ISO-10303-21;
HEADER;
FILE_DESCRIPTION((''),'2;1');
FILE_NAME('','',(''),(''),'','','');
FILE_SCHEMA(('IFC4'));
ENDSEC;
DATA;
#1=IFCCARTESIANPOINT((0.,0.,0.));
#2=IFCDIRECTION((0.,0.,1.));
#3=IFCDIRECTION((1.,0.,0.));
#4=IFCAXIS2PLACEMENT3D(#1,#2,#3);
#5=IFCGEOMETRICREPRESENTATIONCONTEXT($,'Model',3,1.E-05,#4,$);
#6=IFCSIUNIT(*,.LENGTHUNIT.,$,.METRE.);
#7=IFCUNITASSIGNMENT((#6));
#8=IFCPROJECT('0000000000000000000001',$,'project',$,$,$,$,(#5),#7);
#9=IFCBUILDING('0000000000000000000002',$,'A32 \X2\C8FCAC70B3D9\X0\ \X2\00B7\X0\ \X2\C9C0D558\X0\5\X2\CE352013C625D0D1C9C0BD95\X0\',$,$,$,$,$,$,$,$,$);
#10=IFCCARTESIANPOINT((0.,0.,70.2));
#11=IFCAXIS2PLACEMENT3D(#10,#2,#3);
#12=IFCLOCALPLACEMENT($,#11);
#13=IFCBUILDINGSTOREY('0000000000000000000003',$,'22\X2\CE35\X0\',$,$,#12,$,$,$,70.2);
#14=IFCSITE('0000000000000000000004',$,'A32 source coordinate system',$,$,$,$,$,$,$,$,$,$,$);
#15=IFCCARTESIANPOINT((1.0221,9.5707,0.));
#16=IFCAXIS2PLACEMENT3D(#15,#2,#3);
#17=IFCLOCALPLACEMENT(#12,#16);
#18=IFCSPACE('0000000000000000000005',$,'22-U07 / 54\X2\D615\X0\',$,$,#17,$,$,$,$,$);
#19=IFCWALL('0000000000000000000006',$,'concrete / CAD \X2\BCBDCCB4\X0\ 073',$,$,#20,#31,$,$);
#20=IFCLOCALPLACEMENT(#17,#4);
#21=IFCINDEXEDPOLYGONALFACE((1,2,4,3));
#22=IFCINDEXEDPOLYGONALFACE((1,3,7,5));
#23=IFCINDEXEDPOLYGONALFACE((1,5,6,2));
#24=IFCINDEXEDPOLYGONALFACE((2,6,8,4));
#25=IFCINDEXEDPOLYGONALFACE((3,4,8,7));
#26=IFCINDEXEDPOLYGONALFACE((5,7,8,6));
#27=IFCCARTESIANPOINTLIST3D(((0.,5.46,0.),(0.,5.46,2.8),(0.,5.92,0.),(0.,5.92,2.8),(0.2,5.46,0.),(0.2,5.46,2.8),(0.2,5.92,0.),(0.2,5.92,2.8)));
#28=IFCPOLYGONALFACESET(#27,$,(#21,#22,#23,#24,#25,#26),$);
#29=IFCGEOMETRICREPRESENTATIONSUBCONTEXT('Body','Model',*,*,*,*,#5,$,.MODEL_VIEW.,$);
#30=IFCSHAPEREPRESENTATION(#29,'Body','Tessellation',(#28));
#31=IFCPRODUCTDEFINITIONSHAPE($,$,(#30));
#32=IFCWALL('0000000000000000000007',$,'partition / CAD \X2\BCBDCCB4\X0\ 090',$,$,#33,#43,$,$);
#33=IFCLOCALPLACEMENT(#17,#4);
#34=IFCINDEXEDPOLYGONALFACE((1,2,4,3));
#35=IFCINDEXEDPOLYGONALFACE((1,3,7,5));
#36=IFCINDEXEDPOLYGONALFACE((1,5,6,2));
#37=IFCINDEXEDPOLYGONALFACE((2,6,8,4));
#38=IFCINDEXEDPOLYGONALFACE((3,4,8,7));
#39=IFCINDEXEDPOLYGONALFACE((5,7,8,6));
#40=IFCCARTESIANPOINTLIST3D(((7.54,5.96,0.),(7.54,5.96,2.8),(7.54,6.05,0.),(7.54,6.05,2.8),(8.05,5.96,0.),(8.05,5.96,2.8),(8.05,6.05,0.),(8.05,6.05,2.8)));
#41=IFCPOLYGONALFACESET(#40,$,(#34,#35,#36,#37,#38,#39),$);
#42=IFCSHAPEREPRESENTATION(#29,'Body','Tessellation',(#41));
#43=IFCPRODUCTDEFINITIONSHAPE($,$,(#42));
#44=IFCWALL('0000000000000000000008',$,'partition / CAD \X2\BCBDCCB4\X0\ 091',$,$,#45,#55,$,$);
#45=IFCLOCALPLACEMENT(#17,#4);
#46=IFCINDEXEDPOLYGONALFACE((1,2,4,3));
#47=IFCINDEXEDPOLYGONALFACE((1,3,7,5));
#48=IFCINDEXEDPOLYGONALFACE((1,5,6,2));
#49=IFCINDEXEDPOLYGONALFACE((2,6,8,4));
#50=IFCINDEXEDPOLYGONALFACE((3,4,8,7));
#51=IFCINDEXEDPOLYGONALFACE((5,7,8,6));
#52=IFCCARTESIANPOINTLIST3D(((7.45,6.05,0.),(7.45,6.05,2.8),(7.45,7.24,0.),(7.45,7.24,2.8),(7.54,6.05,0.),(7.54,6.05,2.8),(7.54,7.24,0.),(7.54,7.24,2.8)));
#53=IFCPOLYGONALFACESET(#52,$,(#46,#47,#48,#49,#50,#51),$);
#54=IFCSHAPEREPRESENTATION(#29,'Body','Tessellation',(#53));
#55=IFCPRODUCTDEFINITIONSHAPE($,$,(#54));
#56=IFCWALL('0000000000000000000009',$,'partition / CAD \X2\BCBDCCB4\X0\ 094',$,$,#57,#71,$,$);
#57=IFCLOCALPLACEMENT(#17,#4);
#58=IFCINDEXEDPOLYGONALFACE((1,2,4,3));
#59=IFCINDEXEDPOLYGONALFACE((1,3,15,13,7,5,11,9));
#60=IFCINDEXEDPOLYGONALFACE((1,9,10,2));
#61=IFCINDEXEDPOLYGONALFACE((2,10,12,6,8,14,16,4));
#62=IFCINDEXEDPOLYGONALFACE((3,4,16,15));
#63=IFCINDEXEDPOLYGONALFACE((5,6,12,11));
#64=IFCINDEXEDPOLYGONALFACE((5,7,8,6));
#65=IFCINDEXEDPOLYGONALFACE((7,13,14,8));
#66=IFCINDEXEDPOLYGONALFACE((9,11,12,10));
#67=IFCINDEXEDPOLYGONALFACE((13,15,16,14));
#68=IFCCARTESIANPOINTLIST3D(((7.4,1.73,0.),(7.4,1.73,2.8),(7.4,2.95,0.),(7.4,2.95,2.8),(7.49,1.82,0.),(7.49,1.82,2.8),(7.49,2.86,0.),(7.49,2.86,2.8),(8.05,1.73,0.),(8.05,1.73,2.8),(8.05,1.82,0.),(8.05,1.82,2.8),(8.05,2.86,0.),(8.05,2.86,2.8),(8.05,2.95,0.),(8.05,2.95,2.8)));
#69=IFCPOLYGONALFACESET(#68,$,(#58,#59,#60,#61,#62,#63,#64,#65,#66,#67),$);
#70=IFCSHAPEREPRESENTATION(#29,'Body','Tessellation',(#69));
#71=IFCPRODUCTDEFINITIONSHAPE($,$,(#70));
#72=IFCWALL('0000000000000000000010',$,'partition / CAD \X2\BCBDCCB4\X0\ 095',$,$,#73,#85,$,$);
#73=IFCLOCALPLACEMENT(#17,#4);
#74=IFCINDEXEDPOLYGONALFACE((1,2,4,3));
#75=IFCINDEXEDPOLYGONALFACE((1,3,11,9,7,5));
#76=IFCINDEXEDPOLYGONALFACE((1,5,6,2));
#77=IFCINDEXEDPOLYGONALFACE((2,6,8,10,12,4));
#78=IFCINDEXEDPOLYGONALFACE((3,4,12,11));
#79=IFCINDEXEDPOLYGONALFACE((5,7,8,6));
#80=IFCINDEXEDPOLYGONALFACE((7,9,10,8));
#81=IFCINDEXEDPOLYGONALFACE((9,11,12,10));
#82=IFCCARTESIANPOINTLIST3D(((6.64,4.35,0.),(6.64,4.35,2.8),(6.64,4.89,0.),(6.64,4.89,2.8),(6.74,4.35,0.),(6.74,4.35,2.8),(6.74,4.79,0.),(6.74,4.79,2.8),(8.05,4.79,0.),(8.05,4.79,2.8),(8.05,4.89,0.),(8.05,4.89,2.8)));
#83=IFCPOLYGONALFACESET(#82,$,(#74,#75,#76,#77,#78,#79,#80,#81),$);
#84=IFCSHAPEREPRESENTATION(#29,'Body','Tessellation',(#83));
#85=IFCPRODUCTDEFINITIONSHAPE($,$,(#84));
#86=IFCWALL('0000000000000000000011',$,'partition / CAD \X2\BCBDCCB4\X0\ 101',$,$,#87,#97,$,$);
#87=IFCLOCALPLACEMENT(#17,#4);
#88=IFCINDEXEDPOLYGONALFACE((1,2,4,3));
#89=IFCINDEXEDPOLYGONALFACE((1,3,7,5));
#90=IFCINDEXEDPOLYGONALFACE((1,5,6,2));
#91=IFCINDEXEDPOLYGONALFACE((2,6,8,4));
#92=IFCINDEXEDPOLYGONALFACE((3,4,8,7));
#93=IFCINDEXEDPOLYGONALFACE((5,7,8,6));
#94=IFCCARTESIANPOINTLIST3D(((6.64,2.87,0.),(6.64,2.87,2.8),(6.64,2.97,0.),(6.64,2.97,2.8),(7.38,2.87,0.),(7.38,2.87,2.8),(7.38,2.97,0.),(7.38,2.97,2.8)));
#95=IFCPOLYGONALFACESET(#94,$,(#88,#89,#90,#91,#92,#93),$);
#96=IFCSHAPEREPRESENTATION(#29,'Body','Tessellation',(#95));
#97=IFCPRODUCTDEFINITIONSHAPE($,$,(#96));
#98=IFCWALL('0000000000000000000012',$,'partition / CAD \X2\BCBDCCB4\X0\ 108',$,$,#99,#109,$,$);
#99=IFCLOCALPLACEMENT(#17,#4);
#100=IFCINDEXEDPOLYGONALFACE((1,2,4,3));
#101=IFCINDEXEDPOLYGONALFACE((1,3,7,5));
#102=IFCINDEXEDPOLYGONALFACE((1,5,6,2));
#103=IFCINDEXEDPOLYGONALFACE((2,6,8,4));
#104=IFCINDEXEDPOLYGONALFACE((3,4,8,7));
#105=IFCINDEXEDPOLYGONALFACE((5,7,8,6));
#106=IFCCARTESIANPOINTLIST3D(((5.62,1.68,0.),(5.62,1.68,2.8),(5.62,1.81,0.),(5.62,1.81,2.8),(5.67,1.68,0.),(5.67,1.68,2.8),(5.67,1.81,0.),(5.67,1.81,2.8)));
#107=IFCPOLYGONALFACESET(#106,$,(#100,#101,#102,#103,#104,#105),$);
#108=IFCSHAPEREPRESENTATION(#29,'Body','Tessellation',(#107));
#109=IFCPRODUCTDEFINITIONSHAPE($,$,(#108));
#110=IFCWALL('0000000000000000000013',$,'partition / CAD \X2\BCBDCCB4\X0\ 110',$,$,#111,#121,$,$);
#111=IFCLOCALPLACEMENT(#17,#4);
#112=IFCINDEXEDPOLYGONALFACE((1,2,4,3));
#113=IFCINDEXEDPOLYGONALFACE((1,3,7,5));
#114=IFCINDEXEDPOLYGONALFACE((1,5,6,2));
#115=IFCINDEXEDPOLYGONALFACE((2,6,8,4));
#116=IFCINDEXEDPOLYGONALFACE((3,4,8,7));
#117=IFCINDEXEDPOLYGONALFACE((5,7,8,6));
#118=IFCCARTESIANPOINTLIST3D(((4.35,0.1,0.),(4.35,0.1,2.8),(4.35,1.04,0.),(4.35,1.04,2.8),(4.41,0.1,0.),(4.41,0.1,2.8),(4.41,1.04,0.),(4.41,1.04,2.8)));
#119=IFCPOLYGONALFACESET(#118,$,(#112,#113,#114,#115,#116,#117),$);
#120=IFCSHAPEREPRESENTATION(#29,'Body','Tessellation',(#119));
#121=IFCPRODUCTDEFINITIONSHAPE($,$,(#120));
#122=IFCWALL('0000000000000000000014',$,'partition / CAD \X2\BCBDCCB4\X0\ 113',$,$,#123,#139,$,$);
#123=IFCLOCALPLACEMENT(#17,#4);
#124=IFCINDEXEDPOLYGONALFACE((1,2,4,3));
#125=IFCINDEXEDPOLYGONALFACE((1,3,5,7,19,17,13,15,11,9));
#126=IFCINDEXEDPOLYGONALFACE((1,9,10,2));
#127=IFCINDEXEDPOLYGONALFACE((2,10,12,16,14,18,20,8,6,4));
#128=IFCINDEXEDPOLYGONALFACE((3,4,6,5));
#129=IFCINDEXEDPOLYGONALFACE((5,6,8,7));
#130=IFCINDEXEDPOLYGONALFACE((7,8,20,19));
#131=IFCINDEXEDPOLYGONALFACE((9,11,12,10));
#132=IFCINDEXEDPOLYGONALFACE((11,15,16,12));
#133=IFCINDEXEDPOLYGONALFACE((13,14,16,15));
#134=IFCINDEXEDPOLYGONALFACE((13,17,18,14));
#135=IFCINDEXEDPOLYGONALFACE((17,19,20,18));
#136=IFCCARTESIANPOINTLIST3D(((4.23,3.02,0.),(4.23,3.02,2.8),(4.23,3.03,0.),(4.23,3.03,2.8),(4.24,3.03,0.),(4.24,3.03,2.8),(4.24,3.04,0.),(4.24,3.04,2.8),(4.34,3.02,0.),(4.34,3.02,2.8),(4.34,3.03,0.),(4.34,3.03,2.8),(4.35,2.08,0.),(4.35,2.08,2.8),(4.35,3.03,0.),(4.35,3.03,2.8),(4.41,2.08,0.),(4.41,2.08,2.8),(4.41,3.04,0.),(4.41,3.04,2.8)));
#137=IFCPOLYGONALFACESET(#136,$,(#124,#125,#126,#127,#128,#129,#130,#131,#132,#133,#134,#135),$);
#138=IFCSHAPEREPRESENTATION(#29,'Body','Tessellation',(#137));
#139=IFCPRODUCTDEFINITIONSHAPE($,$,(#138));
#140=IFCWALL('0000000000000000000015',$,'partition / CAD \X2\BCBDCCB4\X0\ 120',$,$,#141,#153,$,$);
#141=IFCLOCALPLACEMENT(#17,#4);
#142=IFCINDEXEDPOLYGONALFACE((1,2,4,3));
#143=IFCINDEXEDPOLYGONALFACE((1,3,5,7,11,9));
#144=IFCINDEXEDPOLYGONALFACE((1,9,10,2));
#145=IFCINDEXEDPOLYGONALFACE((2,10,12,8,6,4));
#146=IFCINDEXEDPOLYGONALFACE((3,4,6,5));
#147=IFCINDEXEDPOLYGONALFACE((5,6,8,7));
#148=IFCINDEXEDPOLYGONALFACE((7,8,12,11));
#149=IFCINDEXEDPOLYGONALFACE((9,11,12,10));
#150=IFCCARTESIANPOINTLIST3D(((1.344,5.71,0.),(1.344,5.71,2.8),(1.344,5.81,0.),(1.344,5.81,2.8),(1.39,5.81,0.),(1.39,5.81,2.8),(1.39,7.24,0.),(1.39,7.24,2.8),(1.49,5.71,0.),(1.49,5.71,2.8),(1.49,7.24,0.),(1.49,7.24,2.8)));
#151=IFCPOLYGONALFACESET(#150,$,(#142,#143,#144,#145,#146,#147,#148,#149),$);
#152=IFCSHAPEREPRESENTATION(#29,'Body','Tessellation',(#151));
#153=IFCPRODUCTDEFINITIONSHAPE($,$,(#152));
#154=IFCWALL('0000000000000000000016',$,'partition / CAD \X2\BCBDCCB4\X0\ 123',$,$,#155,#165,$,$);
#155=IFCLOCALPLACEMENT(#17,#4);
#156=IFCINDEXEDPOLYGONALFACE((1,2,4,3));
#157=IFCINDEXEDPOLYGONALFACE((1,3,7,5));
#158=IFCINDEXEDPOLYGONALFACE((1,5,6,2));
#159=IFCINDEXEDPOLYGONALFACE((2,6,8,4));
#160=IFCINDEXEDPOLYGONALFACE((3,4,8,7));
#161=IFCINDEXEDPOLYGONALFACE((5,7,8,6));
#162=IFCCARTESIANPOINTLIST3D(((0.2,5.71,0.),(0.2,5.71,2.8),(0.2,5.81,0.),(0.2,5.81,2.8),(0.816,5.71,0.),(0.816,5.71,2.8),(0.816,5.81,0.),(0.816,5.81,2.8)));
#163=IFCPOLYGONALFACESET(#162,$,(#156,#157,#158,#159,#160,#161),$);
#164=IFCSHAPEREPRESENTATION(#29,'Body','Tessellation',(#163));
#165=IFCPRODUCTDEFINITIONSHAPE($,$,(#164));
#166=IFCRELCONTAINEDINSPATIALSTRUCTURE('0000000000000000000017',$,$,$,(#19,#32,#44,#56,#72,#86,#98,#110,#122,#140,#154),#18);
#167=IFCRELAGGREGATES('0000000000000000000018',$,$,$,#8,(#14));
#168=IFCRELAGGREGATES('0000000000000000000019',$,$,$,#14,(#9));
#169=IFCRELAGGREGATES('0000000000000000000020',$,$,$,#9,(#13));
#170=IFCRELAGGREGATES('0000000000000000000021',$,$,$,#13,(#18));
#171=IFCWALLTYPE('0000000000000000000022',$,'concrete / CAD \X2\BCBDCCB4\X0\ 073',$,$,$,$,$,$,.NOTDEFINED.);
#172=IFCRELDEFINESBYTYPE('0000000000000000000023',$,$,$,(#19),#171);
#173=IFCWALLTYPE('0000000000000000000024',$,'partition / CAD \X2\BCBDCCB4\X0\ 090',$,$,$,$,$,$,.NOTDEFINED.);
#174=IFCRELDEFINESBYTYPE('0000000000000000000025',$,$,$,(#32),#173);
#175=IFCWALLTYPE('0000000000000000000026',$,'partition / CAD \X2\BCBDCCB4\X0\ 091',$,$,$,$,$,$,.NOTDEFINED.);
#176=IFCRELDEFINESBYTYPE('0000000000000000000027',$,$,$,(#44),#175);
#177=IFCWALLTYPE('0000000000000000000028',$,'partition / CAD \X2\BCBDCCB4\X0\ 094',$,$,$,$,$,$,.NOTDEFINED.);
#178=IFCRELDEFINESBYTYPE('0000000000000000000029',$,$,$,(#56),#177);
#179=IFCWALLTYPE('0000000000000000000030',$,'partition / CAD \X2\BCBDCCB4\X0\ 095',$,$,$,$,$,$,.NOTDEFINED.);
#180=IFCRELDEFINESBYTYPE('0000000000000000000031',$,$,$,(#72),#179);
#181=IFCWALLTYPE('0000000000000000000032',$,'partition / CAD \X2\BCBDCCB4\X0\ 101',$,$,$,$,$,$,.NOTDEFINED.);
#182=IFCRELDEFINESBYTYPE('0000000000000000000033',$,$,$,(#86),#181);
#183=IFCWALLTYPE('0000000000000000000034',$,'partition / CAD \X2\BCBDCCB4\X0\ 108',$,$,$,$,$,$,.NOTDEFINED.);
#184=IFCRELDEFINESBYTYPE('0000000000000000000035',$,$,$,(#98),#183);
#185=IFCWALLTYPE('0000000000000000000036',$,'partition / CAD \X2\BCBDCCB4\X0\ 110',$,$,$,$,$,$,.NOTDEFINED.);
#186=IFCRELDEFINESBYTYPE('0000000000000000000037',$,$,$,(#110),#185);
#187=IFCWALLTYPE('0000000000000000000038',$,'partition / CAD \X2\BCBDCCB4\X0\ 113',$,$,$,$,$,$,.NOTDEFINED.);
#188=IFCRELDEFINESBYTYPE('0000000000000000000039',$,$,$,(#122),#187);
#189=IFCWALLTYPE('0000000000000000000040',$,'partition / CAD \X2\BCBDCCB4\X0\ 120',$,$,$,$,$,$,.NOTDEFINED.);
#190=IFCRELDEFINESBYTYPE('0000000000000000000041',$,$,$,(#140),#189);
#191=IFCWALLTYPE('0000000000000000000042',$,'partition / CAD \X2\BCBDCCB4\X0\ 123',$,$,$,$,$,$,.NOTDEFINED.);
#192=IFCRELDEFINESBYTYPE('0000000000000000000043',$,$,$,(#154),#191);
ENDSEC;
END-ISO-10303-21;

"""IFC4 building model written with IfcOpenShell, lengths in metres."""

from ifc_helpers import new_model, si_unit, frame, origin, origin_with_axes, place, context, subcontext, project, spatial, polyline, outline, extrude, source, transform, mapped, type_object, type_shapes, element, save


model = new_model("IFC4")

# Units and contexts
model_context = context("Model", 3, precision=1e-05, world=origin_with_axes())
body_context = subcontext(model_context, "Body", "Model", "MODEL_VIEW")
ifc_project = project(units=[si_unit("LENGTHUNIT", "METRE")], contexts=[model_context])

# Site, building, storey, space
site = spatial("IfcSite", under=ifc_project, Name="A32 source coordinate system")
building = spatial("IfcBuilding", under=site, Name="A32 주거동 · 지하5층–옥탑지붕")
storey_placement = place(None, frame((0.0, 0.0, 70.2), z_axis=(0.0, 0.0, 1.0), x_axis=(1.0, 0.0, 0.0)))
storey = spatial("IfcBuildingStorey", under=building, at=storey_placement, Name="22층", Elevation=70.2)
space_1_placement = place(storey_placement, frame((1.0221, 9.5707, 0.0), z_axis=(0.0, 0.0, 1.0), x_axis=(1.0, 0.0, 0.0)))
space_1 = spatial("IfcSpace", under=storey, at=space_1_placement, Name="22-U07 / 54형")

# Walls
wall_type_1 = type_object("IfcWallType", Name="concrete / CAD 벽체 073", PredefinedType="NOTDEFINED")
shared_shape_1 = source(origin(), body_context, "Body", "SweptSolid", [
    extrude(outline(polyline([(0.2, 5.92), (0.2, 5.46), (0.0, 5.46), (0.0, 5.92), (0.2, 5.92)])), origin(), (0.0, 0.0, 1.0), 2.8),
])
type_shapes(wall_type_1, [shared_shape_1])
wall_1_placement = place(space_1_placement, origin_with_axes())
element("IfcWall", 1, at=wall_1_placement, inside=space_1, type_object=wall_type_1, Name="concrete / CAD 벽체 073", context=body_context, shape_type="MappedRepresentation", body=[
    mapped(shared_shape_1, transform((0.0, 0.0, 0.0), scale=1.0)),
])
wall_type_2 = type_object("IfcWallType", Name="partition / CAD 벽체 090", PredefinedType="NOTDEFINED")
shared_shape_2 = source(origin(), body_context, "Body", "SweptSolid", [
    extrude(outline(polyline([(7.54, 5.96), (7.54, 6.05), (8.05, 6.05), (8.05, 5.96), (7.54, 5.96)])), origin(), (0.0, 0.0, 1.0), 2.8),
])
type_shapes(wall_type_2, [shared_shape_2])
wall_2_placement = place(space_1_placement, origin_with_axes())
element("IfcWall", 2, at=wall_2_placement, inside=space_1, type_object=wall_type_2, Name="partition / CAD 벽체 090", context=body_context, shape_type="MappedRepresentation", body=[
    mapped(shared_shape_2, transform((0.0, 0.0, 0.0), scale=1.0)),
])
wall_type_3 = type_object("IfcWallType", Name="partition / CAD 벽체 091", PredefinedType="NOTDEFINED")
shared_shape_3 = source(origin(), body_context, "Body", "SweptSolid", [
    extrude(outline(polyline([(7.54, 6.05), (7.45, 6.05), (7.45, 7.24), (7.54, 7.24), (7.54, 6.05)])), origin(), (0.0, 0.0, 1.0), 2.8),
])
type_shapes(wall_type_3, [shared_shape_3])
wall_3_placement = place(space_1_placement, origin_with_axes())
element("IfcWall", 3, at=wall_3_placement, inside=space_1, type_object=wall_type_3, Name="partition / CAD 벽체 091", context=body_context, shape_type="MappedRepresentation", body=[
    mapped(shared_shape_3, transform((0.0, 0.0, 0.0), scale=1.0)),
])
wall_type_4 = type_object("IfcWallType", Name="partition / CAD 벽체 094", PredefinedType="NOTDEFINED")
shared_shape_4 = source(origin(), body_context, "Body", "SweptSolid", [
    extrude(outline(polyline([(8.05, 1.73), (7.4, 1.73), (7.4, 2.95), (8.05, 2.95), (8.05, 2.86), (7.49, 2.86), (7.49, 1.82), (8.05, 1.82), (8.05, 1.73)])), origin(), (0.0, 0.0, 1.0), 2.8),
])
type_shapes(wall_type_4, [shared_shape_4])
wall_4_placement = place(space_1_placement, origin_with_axes())
element("IfcWall", 4, at=wall_4_placement, inside=space_1, type_object=wall_type_4, Name="partition / CAD 벽체 094", context=body_context, shape_type="MappedRepresentation", body=[
    mapped(shared_shape_4, transform((0.0, 0.0, 0.0), scale=1.0)),
])
wall_type_5 = type_object("IfcWallType", Name="partition / CAD 벽체 095", PredefinedType="NOTDEFINED")
shared_shape_5 = source(origin(), body_context, "Body", "SweptSolid", [
    extrude(outline(polyline([(6.64, 4.89), (8.05, 4.89), (8.05, 4.79), (6.74, 4.79), (6.74, 4.35), (6.64, 4.35), (6.64, 4.89)])), origin(), (0.0, 0.0, 1.0), 2.8),
])
type_shapes(wall_type_5, [shared_shape_5])
wall_5_placement = place(space_1_placement, origin_with_axes())
element("IfcWall", 5, at=wall_5_placement, inside=space_1, type_object=wall_type_5, Name="partition / CAD 벽체 095", context=body_context, shape_type="MappedRepresentation", body=[
    mapped(shared_shape_5, transform((0.0, 0.0, 0.0), scale=1.0)),
])
wall_type_6 = type_object("IfcWallType", Name="partition / CAD 벽체 101", PredefinedType="NOTDEFINED")
shared_shape_6 = source(origin(), body_context, "Body", "SweptSolid", [
    extrude(outline(polyline([(7.38, 2.97), (7.38, 2.87), (6.64, 2.87), (6.64, 2.97), (7.38, 2.97)])), origin(), (0.0, 0.0, 1.0), 2.8),
])
type_shapes(wall_type_6, [shared_shape_6])
wall_6_placement = place(space_1_placement, origin_with_axes())
element("IfcWall", 6, at=wall_6_placement, inside=space_1, type_object=wall_type_6, Name="partition / CAD 벽체 101", context=body_context, shape_type="MappedRepresentation", body=[
    mapped(shared_shape_6, transform((0.0, 0.0, 0.0), scale=1.0)),
])
wall_type_7 = type_object("IfcWallType", Name="partition / CAD 벽체 108", PredefinedType="NOTDEFINED")
shared_shape_7 = source(origin(), body_context, "Body", "SweptSolid", [
    extrude(outline(polyline([(5.67, 1.68), (5.62, 1.68), (5.62, 1.81), (5.67, 1.81), (5.67, 1.68)])), origin(), (0.0, 0.0, 1.0), 2.8),
])
type_shapes(wall_type_7, [shared_shape_7])
wall_7_placement = place(space_1_placement, origin_with_axes())
element("IfcWall", 7, at=wall_7_placement, inside=space_1, type_object=wall_type_7, Name="partition / CAD 벽체 108", context=body_context, shape_type="MappedRepresentation", body=[
    mapped(shared_shape_7, transform((0.0, 0.0, 0.0), scale=1.0)),
])
wall_type_8 = type_object("IfcWallType", Name="partition / CAD 벽체 110", PredefinedType="NOTDEFINED")
shared_shape_8 = source(origin(), body_context, "Body", "SweptSolid", [
    extrude(outline(polyline([(4.35, 1.04), (4.41, 1.04), (4.41, 0.1), (4.35, 0.1), (4.35, 1.04)])), origin(), (0.0, 0.0, 1.0), 2.8),
])
type_shapes(wall_type_8, [shared_shape_8])
wall_8_placement = place(space_1_placement, origin_with_axes())
element("IfcWall", 8, at=wall_8_placement, inside=space_1, type_object=wall_type_8, Name="partition / CAD 벽체 110", context=body_context, shape_type="MappedRepresentation", body=[
    mapped(shared_shape_8, transform((0.0, 0.0, 0.0), scale=1.0)),
])
wall_type_9 = type_object("IfcWallType", Name="partition / CAD 벽체 113", PredefinedType="NOTDEFINED")
shared_shape_9 = source(origin(), body_context, "Body", "SweptSolid", [
    extrude(outline(polyline([(4.24, 3.04), (4.41, 3.04), (4.41, 2.08), (4.35, 2.08), (4.35, 3.03), (4.34, 3.03), (4.34, 3.02), (4.23, 3.02), (4.23, 3.03), (4.24, 3.03), (4.24, 3.04)])), origin(), (0.0, 0.0, 1.0), 2.8),
])
type_shapes(wall_type_9, [shared_shape_9])
wall_9_placement = place(space_1_placement, origin_with_axes())
element("IfcWall", 9, at=wall_9_placement, inside=space_1, type_object=wall_type_9, Name="partition / CAD 벽체 113", context=body_context, shape_type="MappedRepresentation", body=[
    mapped(shared_shape_9, transform((0.0, 0.0, 0.0), scale=1.0)),
])
wall_type_10 = type_object("IfcWallType", Name="partition / CAD 벽체 120", PredefinedType="NOTDEFINED")
shared_shape_10 = source(origin(), body_context, "Body", "SweptSolid", [
    extrude(outline(polyline([(1.39, 7.24), (1.49, 7.24), (1.49, 5.71), (1.344, 5.71), (1.344, 5.81), (1.39, 5.81), (1.39, 7.24)])), origin(), (0.0, 0.0, 1.0), 2.8),
])
type_shapes(wall_type_10, [shared_shape_10])
wall_10_placement = place(space_1_placement, origin_with_axes())
element("IfcWall", 10, at=wall_10_placement, inside=space_1, type_object=wall_type_10, Name="partition / CAD 벽체 120", context=body_context, shape_type="MappedRepresentation", body=[
    mapped(shared_shape_10, transform((0.0, 0.0, 0.0), scale=1.0)),
])
wall_type_11 = type_object("IfcWallType", Name="partition / CAD 벽체 123", PredefinedType="NOTDEFINED")
shared_shape_11 = source(origin(), body_context, "Body", "SweptSolid", [
    extrude(outline(polyline([(0.816, 5.81), (0.816, 5.71), (0.2, 5.71), (0.2, 5.81), (0.816, 5.81)])), origin(), (0.0, 0.0, 1.0), 2.8),
])
type_shapes(wall_type_11, [shared_shape_11])
wall_11_placement = place(space_1_placement, origin_with_axes())
element("IfcWall", 11, at=wall_11_placement, inside=space_1, type_object=wall_type_11, Name="partition / CAD 벽체 123", context=body_context, shape_type="MappedRepresentation", body=[
    mapped(shared_shape_11, transform((0.0, 0.0, 0.0), scale=1.0)),
])

save(model, "model.ifc")
